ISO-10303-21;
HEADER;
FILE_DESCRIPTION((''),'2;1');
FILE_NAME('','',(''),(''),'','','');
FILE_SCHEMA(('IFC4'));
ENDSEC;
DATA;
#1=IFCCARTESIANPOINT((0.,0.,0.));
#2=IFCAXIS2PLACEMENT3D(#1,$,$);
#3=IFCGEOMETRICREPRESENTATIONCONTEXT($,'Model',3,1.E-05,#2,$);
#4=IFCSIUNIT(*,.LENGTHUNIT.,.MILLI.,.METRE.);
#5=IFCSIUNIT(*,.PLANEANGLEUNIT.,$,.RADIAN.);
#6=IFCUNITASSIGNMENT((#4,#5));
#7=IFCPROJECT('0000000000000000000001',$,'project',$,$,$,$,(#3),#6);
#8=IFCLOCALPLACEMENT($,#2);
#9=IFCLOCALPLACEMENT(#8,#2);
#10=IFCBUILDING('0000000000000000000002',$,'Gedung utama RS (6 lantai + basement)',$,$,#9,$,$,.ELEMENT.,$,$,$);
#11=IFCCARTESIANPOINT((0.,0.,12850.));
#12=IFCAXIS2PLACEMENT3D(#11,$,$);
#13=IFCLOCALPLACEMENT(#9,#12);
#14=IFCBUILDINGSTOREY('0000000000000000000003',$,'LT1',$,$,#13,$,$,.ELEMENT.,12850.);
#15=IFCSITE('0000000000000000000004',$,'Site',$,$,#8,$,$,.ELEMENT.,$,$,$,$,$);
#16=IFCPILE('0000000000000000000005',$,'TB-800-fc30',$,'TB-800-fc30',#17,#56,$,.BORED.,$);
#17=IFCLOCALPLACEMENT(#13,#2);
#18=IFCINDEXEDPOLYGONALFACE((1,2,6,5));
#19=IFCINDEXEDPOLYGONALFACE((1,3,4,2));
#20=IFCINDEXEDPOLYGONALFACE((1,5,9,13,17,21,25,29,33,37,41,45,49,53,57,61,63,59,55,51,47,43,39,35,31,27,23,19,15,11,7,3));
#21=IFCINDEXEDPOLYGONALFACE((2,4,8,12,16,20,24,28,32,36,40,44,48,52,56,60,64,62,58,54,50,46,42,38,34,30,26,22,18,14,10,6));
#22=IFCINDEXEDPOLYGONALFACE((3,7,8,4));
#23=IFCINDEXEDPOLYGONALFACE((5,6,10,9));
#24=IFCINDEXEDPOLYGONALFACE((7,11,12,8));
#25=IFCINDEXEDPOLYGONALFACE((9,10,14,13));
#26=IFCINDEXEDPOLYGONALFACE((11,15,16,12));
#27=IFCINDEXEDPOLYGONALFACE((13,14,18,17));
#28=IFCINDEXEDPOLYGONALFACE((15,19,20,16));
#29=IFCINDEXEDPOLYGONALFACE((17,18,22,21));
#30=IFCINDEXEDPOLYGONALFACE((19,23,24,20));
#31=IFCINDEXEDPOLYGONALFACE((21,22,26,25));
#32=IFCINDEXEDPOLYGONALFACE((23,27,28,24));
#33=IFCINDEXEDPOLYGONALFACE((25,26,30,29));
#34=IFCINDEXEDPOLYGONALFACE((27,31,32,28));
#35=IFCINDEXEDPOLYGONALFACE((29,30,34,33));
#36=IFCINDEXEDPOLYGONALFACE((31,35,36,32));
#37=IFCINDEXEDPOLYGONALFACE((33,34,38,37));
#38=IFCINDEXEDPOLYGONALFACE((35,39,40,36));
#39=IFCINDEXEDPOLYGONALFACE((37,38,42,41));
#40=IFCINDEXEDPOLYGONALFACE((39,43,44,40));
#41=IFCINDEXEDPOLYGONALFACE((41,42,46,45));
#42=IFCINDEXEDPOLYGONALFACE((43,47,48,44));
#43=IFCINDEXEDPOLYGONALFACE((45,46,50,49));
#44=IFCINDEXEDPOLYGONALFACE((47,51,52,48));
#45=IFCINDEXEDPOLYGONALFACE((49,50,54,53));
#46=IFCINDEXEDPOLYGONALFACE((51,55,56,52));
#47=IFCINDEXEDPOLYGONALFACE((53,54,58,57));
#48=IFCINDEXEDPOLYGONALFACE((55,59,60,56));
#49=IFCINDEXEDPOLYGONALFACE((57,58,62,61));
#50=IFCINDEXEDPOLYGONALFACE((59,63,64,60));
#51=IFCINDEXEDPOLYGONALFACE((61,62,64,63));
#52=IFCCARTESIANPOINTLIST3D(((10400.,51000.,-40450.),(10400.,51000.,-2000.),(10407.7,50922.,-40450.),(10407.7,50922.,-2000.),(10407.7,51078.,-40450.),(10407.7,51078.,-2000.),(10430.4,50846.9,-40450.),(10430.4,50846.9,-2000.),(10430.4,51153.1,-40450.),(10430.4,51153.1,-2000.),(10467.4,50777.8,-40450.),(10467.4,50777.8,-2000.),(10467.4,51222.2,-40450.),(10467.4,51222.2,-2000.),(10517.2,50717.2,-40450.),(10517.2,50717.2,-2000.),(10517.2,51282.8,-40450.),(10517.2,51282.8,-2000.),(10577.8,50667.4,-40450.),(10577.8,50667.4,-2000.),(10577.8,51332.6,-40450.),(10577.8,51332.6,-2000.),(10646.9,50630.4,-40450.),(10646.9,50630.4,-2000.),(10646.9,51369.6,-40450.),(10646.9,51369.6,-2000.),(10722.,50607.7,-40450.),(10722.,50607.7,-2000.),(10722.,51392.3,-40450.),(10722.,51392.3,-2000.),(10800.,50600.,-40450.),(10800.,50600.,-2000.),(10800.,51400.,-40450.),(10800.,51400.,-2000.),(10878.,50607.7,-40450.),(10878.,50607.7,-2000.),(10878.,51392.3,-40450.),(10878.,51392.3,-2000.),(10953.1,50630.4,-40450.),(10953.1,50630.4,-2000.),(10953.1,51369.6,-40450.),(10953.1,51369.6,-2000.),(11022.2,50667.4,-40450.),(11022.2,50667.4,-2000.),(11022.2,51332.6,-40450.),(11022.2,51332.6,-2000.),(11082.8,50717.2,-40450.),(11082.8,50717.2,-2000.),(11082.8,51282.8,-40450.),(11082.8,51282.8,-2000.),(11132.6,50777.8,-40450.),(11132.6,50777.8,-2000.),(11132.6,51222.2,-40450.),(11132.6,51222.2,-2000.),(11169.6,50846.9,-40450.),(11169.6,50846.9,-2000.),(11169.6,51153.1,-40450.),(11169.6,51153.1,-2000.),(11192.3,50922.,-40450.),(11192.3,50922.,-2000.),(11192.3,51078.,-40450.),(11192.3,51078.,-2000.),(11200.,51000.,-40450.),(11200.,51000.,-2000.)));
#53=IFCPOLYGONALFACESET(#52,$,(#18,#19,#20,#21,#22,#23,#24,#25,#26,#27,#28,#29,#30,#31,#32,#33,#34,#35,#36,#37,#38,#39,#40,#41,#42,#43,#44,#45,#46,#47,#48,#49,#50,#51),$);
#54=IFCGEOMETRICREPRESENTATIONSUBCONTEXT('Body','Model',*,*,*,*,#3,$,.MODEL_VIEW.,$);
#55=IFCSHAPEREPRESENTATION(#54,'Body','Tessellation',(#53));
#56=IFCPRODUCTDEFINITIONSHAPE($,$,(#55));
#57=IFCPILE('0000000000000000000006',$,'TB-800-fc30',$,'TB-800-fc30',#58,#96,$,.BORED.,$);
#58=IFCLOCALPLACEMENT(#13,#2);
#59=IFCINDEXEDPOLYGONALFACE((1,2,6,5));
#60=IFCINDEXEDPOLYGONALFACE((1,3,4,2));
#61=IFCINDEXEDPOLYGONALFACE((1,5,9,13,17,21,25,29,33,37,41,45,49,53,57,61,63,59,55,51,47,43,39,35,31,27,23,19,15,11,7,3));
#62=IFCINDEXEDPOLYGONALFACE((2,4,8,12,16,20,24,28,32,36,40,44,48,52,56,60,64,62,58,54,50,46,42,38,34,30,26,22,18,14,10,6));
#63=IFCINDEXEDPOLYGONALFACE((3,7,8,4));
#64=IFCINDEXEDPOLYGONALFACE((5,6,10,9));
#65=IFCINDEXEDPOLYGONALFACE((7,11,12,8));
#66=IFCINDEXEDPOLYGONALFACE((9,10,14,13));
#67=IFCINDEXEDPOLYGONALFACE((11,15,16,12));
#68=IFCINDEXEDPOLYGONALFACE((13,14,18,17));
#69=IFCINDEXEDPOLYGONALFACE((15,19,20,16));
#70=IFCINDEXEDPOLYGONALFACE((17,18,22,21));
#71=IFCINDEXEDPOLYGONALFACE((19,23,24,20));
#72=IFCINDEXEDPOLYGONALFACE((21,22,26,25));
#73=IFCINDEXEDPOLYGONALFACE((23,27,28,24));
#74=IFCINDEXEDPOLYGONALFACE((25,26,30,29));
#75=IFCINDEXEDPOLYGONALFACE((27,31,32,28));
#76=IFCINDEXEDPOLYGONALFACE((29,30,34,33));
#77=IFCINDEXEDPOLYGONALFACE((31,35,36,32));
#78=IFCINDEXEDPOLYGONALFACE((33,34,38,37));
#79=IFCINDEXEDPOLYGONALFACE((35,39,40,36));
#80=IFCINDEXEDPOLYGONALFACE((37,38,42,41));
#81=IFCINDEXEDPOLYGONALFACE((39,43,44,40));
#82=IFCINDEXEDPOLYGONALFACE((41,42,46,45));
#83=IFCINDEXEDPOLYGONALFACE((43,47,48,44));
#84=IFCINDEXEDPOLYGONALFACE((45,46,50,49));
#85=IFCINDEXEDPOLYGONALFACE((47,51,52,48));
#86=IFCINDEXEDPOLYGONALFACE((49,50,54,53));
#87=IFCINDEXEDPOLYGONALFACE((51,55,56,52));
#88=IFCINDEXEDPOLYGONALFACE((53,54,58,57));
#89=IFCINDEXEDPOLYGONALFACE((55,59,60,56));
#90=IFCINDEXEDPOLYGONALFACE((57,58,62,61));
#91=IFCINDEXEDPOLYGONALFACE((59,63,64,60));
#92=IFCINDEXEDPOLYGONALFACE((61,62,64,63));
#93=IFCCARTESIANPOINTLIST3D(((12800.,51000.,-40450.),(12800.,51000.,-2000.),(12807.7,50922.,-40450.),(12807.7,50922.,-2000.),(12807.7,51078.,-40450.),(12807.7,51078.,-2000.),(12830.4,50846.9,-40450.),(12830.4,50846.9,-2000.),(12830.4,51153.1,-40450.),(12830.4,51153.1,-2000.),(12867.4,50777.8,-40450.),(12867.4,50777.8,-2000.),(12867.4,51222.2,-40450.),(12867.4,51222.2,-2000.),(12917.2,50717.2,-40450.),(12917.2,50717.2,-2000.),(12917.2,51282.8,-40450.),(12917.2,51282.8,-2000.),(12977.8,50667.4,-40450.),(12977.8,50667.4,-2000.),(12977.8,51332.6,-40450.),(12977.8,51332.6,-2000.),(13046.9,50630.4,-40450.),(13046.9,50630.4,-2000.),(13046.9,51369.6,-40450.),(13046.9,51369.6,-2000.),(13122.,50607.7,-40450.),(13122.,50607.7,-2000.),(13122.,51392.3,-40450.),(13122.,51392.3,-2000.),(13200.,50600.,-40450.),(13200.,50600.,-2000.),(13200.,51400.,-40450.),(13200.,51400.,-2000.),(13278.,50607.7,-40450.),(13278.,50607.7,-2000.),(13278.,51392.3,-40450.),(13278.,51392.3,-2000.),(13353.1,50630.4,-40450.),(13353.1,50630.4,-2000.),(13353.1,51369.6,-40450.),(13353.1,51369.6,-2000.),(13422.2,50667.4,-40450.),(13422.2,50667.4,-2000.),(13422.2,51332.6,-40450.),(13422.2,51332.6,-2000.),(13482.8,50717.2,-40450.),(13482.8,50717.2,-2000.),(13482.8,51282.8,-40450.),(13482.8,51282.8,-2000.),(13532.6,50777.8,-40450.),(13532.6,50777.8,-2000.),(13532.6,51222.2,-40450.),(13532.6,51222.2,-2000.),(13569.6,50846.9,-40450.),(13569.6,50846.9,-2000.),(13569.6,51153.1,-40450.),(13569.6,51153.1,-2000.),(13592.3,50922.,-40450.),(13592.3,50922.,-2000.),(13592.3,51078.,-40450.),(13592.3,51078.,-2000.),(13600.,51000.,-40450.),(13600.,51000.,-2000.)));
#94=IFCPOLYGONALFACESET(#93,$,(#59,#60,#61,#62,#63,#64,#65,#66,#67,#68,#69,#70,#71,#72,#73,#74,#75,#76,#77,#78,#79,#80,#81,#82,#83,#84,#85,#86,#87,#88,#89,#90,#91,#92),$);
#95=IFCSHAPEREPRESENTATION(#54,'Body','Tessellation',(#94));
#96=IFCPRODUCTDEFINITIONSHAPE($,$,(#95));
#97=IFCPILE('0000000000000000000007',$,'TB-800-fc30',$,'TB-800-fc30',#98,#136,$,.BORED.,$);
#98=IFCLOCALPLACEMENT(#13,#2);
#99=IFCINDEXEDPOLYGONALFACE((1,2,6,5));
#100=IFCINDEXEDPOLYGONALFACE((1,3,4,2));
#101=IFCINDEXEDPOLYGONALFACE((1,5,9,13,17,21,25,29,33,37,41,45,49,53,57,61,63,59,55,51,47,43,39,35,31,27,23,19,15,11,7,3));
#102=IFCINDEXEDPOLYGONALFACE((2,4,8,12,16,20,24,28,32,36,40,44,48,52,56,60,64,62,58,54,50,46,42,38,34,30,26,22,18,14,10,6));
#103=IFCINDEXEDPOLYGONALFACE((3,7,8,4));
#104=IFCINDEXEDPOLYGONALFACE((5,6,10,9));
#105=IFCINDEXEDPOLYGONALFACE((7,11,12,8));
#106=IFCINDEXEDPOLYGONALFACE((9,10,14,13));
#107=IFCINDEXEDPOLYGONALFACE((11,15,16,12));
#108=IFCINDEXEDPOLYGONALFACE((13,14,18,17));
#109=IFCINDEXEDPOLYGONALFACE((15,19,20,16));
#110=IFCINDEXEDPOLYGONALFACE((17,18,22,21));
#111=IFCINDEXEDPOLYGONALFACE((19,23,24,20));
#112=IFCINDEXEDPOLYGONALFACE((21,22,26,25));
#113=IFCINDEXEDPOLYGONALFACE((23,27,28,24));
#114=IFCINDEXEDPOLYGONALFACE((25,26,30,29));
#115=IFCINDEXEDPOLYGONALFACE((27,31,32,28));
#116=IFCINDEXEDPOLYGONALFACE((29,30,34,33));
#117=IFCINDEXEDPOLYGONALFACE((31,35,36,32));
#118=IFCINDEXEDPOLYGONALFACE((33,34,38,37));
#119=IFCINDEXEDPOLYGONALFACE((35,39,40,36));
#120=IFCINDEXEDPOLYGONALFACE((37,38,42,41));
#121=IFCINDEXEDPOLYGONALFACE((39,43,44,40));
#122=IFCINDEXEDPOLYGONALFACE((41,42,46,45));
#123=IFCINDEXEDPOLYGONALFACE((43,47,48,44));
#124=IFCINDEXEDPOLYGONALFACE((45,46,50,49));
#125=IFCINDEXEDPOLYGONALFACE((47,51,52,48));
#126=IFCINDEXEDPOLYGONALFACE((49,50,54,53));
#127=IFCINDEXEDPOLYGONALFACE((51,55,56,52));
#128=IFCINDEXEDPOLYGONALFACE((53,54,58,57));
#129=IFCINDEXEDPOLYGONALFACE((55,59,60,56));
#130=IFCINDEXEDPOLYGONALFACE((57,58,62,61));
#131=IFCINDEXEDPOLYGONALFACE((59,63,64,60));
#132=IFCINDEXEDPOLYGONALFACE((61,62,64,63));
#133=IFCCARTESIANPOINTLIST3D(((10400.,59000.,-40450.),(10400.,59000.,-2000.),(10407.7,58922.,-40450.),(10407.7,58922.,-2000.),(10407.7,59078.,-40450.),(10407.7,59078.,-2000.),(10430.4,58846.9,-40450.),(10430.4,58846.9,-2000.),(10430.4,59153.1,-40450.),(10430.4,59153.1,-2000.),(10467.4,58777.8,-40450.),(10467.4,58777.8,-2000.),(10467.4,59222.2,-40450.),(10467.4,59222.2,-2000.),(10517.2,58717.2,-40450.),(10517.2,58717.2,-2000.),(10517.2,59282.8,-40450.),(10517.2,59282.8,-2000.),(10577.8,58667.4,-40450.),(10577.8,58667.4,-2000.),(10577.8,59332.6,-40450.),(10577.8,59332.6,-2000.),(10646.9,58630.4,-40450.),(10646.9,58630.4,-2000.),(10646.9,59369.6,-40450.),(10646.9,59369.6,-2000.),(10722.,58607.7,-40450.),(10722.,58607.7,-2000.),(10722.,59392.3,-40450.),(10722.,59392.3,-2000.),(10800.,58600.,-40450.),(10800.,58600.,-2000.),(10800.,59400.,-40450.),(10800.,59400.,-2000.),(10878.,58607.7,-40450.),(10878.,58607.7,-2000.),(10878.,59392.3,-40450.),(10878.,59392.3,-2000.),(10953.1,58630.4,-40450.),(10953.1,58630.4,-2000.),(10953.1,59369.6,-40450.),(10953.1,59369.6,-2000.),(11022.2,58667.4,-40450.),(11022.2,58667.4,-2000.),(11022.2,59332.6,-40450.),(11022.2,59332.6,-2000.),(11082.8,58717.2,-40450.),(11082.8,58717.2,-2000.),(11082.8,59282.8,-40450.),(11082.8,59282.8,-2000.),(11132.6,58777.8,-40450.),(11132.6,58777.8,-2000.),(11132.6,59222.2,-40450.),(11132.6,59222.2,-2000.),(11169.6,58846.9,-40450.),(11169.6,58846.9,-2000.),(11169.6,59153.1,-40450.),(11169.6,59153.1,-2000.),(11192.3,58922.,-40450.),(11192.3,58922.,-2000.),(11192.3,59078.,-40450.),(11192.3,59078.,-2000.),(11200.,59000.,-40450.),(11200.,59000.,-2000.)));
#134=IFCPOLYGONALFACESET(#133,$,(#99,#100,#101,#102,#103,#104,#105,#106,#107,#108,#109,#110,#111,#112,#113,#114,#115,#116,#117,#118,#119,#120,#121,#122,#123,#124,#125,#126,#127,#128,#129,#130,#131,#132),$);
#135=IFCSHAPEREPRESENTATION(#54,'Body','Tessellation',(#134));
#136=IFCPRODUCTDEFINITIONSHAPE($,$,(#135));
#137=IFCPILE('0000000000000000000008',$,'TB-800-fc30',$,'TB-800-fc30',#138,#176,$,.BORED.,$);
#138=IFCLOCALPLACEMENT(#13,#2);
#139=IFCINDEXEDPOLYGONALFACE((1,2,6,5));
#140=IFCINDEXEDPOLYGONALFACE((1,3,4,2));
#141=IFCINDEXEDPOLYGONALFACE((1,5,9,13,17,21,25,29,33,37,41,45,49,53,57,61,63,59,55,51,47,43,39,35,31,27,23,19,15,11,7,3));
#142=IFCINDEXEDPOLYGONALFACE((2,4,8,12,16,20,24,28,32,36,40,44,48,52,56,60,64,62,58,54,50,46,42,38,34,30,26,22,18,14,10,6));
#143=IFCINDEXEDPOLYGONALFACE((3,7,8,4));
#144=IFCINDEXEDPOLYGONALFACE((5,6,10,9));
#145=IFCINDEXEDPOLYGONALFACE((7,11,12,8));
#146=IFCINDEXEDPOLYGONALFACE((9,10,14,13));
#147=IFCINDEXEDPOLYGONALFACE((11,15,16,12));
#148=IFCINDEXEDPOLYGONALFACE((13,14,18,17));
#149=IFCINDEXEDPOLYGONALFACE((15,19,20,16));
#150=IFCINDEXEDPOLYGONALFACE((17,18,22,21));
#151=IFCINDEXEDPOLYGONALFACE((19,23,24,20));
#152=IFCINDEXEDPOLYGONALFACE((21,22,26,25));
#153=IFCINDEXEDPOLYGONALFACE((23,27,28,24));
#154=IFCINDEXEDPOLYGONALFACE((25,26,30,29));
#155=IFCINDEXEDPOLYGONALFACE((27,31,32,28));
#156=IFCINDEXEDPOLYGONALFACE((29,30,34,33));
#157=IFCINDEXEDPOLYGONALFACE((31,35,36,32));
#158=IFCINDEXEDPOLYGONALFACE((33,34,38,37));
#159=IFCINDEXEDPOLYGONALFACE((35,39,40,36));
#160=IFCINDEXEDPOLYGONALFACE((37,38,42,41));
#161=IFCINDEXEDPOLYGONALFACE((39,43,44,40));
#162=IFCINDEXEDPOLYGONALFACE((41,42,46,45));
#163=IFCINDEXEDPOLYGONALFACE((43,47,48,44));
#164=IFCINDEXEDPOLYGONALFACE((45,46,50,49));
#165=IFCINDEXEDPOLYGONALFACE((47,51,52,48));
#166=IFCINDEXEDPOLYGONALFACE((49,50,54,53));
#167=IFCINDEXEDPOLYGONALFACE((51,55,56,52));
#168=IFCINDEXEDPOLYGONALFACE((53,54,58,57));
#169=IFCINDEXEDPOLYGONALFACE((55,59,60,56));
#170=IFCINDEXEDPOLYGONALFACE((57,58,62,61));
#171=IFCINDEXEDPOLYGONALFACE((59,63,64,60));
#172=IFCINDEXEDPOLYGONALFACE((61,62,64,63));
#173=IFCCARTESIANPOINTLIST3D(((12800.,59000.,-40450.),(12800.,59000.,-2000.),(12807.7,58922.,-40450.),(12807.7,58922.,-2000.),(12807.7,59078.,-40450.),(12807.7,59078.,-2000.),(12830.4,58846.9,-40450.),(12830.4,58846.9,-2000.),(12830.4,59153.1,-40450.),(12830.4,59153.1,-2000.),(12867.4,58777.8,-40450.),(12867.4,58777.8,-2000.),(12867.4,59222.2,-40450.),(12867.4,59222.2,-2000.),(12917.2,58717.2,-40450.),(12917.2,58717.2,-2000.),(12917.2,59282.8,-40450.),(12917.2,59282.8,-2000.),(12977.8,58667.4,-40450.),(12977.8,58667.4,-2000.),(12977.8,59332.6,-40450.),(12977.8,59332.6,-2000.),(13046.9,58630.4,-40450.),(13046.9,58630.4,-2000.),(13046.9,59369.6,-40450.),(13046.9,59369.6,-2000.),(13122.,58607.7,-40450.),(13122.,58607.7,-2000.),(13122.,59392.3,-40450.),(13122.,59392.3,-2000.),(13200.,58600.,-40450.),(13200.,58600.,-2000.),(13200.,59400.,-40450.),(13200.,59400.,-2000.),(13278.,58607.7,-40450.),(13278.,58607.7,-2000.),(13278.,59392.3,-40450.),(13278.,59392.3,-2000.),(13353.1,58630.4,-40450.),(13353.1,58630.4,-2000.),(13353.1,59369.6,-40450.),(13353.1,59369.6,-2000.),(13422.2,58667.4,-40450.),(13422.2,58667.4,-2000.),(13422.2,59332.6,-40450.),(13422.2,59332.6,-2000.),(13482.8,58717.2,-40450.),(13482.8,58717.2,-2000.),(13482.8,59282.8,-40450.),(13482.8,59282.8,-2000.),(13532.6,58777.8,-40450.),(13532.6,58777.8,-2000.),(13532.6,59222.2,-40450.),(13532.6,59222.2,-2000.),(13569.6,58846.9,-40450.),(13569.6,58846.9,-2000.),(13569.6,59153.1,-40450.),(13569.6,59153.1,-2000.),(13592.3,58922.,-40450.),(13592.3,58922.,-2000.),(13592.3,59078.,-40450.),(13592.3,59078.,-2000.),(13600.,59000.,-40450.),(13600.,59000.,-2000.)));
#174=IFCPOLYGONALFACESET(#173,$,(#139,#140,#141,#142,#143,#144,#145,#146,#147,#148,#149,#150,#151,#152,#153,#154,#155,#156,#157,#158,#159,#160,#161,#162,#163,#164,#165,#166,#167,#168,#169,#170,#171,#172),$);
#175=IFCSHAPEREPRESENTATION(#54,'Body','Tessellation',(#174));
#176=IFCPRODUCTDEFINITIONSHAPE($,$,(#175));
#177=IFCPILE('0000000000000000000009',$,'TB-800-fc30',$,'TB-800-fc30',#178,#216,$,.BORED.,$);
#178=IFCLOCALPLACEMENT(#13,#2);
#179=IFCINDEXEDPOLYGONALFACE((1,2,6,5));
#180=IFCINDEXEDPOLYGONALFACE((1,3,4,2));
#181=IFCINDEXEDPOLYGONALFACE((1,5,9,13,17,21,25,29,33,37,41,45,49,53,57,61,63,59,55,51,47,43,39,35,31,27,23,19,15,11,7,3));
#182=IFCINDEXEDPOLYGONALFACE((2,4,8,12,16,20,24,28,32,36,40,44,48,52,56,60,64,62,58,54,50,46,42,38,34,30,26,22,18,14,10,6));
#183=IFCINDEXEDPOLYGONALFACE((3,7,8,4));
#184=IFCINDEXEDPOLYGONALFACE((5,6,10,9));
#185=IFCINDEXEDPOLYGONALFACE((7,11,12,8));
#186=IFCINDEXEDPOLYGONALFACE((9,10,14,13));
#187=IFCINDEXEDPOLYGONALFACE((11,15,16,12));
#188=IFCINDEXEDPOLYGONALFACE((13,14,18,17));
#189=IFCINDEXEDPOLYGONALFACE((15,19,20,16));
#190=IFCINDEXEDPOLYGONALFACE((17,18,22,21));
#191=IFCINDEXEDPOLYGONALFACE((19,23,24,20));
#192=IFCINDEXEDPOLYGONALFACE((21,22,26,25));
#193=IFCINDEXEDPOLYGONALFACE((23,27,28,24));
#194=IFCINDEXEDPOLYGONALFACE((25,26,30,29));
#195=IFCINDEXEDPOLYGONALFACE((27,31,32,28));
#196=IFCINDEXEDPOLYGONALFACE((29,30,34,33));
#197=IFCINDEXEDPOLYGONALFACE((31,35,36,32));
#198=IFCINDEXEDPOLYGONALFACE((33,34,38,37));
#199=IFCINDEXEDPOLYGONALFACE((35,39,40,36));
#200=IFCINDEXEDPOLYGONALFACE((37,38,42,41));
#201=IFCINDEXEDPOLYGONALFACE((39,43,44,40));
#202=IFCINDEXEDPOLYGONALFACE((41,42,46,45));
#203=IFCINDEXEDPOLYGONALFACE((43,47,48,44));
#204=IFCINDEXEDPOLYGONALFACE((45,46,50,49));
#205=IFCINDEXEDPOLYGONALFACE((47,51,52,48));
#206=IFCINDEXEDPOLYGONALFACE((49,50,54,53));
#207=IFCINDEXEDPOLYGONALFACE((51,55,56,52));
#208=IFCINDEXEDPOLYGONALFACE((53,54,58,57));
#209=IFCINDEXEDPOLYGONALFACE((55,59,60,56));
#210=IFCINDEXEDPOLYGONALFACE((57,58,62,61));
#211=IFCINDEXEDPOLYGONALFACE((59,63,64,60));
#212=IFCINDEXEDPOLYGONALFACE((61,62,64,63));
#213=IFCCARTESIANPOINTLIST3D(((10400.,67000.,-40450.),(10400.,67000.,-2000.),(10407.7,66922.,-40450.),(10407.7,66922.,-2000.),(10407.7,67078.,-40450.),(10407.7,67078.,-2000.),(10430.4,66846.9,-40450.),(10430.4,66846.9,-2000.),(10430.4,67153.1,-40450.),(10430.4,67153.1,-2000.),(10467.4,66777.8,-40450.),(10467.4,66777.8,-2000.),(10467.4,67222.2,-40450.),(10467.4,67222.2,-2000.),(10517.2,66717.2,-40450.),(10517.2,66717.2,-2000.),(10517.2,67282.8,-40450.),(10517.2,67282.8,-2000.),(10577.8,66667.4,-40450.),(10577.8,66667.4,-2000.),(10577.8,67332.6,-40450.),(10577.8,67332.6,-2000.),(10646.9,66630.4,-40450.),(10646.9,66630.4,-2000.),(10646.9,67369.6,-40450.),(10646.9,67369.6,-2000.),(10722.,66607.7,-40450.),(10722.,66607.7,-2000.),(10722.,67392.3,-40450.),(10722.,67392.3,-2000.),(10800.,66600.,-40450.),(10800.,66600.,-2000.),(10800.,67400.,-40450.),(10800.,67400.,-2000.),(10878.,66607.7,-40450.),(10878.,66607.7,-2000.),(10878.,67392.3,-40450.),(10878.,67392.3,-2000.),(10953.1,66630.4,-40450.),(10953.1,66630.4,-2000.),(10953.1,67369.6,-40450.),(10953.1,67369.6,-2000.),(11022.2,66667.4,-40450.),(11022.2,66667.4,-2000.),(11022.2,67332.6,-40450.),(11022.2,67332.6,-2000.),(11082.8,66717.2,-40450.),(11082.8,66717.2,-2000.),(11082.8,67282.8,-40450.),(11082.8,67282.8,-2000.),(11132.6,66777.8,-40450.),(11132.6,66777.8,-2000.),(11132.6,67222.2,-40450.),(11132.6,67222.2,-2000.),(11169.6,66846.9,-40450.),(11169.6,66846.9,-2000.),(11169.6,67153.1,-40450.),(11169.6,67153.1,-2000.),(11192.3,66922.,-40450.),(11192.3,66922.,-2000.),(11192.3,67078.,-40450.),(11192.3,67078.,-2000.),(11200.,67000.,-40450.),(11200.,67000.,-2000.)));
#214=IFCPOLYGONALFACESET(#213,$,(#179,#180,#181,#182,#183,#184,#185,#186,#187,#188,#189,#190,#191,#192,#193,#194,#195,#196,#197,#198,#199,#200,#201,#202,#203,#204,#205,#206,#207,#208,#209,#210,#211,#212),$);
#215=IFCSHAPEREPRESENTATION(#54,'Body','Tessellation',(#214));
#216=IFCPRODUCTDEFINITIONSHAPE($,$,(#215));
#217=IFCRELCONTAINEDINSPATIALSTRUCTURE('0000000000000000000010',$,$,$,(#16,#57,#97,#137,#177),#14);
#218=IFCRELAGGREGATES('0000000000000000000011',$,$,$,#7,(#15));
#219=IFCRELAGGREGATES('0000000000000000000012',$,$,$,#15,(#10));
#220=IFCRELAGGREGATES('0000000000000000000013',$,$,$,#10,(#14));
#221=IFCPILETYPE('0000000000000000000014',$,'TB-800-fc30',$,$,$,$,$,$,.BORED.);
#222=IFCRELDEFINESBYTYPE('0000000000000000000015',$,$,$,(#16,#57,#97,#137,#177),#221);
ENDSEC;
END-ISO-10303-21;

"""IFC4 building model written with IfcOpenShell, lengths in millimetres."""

from ifc_helpers import new_model, si_unit, frame, origin, origin_2d, place, context, subcontext, project, spatial, circle, extrude, material_profile, profile_set, profile_usage, type_object, element, save


model = new_model("IFC4")

# Units and contexts
model_context = context("Model", 3, precision=1e-05, world=origin())
body_context = subcontext(model_context, "Body", "Model", "MODEL_VIEW")
ifc_project = project(units=[si_unit("LENGTHUNIT", "METRE", prefix="MILLI"), si_unit("PLANEANGLEUNIT", "RADIAN")], contexts=[model_context])

# Site, building, storey
site_placement = place(None, origin())
site = spatial("IfcSite", under=ifc_project, at=site_placement, Name="Site", CompositionType="ELEMENT")
building_placement = place(site_placement, origin())
building = spatial("IfcBuilding", under=site, at=building_placement, Name="Gedung utama RS (6 lantai + basement)", CompositionType="ELEMENT")
storey_placement = place(building_placement, frame((0.0, 0.0, 12850.0)))
storey = spatial("IfcBuildingStorey", under=building, at=storey_placement, Name="LT1", CompositionType="ELEMENT", Elevation=12850.0)

# Piles
ifc_material_profile = material_profile(None, circle(Radius=400.0, at=origin_2d()), Name="TB-800-fc30")
ifc_profile_set = profile_set([ifc_material_profile], Name="TB-800-fc30")
ifc_profile_usage = profile_usage(ifc_profile_set, cardinal=5)
pile_type = type_object("IfcPileType", Name="TB-800-fc30", PredefinedType="BORED", material=ifc_profile_set)
for number, where, z_axis, x_axis, name in (
    (1, (10800.0, 51000.0, -40450.0), (0.0, 0.0, 1.0), (1.0, 0.0, 0.0), "TB-800-fc30"),
    (2, (13200.0, 51000.0, -40450.0), (0.0, 0.0, 1.0), (1.0, 0.0, 0.0), "TB-800-fc30"),
    (3, (10800.0, 59000.0, -40450.0), (0.0, 0.0, 1.0), (1.0, 0.0, 0.0), "TB-800-fc30"),
    (4, (13200.0, 59000.0, -40450.0), (0.0, 0.0, 1.0), (1.0, 0.0, 0.0), "TB-800-fc30"),
    (5, (10800.0, 67000.0, -40450.0), (0.0, 0.0, 1.0), (1.0, 0.0, 0.0), "TB-800-fc30"),
):
    element("IfcPile", number, at=place(storey_placement, frame(where, z_axis=z_axis, x_axis=x_axis)), inside=storey, type_object=pile_type, material=ifc_profile_usage, Name=name, ObjectType="TB-800-fc30", PredefinedType="BORED", context=body_context, shape_type="SweptSolid", body=[
        extrude(circle(Radius=400.0, at=origin_2d()), origin(), (0.0, 0.0, 1.0), 38450.0),
    ])

save(model, "model.ifc")
